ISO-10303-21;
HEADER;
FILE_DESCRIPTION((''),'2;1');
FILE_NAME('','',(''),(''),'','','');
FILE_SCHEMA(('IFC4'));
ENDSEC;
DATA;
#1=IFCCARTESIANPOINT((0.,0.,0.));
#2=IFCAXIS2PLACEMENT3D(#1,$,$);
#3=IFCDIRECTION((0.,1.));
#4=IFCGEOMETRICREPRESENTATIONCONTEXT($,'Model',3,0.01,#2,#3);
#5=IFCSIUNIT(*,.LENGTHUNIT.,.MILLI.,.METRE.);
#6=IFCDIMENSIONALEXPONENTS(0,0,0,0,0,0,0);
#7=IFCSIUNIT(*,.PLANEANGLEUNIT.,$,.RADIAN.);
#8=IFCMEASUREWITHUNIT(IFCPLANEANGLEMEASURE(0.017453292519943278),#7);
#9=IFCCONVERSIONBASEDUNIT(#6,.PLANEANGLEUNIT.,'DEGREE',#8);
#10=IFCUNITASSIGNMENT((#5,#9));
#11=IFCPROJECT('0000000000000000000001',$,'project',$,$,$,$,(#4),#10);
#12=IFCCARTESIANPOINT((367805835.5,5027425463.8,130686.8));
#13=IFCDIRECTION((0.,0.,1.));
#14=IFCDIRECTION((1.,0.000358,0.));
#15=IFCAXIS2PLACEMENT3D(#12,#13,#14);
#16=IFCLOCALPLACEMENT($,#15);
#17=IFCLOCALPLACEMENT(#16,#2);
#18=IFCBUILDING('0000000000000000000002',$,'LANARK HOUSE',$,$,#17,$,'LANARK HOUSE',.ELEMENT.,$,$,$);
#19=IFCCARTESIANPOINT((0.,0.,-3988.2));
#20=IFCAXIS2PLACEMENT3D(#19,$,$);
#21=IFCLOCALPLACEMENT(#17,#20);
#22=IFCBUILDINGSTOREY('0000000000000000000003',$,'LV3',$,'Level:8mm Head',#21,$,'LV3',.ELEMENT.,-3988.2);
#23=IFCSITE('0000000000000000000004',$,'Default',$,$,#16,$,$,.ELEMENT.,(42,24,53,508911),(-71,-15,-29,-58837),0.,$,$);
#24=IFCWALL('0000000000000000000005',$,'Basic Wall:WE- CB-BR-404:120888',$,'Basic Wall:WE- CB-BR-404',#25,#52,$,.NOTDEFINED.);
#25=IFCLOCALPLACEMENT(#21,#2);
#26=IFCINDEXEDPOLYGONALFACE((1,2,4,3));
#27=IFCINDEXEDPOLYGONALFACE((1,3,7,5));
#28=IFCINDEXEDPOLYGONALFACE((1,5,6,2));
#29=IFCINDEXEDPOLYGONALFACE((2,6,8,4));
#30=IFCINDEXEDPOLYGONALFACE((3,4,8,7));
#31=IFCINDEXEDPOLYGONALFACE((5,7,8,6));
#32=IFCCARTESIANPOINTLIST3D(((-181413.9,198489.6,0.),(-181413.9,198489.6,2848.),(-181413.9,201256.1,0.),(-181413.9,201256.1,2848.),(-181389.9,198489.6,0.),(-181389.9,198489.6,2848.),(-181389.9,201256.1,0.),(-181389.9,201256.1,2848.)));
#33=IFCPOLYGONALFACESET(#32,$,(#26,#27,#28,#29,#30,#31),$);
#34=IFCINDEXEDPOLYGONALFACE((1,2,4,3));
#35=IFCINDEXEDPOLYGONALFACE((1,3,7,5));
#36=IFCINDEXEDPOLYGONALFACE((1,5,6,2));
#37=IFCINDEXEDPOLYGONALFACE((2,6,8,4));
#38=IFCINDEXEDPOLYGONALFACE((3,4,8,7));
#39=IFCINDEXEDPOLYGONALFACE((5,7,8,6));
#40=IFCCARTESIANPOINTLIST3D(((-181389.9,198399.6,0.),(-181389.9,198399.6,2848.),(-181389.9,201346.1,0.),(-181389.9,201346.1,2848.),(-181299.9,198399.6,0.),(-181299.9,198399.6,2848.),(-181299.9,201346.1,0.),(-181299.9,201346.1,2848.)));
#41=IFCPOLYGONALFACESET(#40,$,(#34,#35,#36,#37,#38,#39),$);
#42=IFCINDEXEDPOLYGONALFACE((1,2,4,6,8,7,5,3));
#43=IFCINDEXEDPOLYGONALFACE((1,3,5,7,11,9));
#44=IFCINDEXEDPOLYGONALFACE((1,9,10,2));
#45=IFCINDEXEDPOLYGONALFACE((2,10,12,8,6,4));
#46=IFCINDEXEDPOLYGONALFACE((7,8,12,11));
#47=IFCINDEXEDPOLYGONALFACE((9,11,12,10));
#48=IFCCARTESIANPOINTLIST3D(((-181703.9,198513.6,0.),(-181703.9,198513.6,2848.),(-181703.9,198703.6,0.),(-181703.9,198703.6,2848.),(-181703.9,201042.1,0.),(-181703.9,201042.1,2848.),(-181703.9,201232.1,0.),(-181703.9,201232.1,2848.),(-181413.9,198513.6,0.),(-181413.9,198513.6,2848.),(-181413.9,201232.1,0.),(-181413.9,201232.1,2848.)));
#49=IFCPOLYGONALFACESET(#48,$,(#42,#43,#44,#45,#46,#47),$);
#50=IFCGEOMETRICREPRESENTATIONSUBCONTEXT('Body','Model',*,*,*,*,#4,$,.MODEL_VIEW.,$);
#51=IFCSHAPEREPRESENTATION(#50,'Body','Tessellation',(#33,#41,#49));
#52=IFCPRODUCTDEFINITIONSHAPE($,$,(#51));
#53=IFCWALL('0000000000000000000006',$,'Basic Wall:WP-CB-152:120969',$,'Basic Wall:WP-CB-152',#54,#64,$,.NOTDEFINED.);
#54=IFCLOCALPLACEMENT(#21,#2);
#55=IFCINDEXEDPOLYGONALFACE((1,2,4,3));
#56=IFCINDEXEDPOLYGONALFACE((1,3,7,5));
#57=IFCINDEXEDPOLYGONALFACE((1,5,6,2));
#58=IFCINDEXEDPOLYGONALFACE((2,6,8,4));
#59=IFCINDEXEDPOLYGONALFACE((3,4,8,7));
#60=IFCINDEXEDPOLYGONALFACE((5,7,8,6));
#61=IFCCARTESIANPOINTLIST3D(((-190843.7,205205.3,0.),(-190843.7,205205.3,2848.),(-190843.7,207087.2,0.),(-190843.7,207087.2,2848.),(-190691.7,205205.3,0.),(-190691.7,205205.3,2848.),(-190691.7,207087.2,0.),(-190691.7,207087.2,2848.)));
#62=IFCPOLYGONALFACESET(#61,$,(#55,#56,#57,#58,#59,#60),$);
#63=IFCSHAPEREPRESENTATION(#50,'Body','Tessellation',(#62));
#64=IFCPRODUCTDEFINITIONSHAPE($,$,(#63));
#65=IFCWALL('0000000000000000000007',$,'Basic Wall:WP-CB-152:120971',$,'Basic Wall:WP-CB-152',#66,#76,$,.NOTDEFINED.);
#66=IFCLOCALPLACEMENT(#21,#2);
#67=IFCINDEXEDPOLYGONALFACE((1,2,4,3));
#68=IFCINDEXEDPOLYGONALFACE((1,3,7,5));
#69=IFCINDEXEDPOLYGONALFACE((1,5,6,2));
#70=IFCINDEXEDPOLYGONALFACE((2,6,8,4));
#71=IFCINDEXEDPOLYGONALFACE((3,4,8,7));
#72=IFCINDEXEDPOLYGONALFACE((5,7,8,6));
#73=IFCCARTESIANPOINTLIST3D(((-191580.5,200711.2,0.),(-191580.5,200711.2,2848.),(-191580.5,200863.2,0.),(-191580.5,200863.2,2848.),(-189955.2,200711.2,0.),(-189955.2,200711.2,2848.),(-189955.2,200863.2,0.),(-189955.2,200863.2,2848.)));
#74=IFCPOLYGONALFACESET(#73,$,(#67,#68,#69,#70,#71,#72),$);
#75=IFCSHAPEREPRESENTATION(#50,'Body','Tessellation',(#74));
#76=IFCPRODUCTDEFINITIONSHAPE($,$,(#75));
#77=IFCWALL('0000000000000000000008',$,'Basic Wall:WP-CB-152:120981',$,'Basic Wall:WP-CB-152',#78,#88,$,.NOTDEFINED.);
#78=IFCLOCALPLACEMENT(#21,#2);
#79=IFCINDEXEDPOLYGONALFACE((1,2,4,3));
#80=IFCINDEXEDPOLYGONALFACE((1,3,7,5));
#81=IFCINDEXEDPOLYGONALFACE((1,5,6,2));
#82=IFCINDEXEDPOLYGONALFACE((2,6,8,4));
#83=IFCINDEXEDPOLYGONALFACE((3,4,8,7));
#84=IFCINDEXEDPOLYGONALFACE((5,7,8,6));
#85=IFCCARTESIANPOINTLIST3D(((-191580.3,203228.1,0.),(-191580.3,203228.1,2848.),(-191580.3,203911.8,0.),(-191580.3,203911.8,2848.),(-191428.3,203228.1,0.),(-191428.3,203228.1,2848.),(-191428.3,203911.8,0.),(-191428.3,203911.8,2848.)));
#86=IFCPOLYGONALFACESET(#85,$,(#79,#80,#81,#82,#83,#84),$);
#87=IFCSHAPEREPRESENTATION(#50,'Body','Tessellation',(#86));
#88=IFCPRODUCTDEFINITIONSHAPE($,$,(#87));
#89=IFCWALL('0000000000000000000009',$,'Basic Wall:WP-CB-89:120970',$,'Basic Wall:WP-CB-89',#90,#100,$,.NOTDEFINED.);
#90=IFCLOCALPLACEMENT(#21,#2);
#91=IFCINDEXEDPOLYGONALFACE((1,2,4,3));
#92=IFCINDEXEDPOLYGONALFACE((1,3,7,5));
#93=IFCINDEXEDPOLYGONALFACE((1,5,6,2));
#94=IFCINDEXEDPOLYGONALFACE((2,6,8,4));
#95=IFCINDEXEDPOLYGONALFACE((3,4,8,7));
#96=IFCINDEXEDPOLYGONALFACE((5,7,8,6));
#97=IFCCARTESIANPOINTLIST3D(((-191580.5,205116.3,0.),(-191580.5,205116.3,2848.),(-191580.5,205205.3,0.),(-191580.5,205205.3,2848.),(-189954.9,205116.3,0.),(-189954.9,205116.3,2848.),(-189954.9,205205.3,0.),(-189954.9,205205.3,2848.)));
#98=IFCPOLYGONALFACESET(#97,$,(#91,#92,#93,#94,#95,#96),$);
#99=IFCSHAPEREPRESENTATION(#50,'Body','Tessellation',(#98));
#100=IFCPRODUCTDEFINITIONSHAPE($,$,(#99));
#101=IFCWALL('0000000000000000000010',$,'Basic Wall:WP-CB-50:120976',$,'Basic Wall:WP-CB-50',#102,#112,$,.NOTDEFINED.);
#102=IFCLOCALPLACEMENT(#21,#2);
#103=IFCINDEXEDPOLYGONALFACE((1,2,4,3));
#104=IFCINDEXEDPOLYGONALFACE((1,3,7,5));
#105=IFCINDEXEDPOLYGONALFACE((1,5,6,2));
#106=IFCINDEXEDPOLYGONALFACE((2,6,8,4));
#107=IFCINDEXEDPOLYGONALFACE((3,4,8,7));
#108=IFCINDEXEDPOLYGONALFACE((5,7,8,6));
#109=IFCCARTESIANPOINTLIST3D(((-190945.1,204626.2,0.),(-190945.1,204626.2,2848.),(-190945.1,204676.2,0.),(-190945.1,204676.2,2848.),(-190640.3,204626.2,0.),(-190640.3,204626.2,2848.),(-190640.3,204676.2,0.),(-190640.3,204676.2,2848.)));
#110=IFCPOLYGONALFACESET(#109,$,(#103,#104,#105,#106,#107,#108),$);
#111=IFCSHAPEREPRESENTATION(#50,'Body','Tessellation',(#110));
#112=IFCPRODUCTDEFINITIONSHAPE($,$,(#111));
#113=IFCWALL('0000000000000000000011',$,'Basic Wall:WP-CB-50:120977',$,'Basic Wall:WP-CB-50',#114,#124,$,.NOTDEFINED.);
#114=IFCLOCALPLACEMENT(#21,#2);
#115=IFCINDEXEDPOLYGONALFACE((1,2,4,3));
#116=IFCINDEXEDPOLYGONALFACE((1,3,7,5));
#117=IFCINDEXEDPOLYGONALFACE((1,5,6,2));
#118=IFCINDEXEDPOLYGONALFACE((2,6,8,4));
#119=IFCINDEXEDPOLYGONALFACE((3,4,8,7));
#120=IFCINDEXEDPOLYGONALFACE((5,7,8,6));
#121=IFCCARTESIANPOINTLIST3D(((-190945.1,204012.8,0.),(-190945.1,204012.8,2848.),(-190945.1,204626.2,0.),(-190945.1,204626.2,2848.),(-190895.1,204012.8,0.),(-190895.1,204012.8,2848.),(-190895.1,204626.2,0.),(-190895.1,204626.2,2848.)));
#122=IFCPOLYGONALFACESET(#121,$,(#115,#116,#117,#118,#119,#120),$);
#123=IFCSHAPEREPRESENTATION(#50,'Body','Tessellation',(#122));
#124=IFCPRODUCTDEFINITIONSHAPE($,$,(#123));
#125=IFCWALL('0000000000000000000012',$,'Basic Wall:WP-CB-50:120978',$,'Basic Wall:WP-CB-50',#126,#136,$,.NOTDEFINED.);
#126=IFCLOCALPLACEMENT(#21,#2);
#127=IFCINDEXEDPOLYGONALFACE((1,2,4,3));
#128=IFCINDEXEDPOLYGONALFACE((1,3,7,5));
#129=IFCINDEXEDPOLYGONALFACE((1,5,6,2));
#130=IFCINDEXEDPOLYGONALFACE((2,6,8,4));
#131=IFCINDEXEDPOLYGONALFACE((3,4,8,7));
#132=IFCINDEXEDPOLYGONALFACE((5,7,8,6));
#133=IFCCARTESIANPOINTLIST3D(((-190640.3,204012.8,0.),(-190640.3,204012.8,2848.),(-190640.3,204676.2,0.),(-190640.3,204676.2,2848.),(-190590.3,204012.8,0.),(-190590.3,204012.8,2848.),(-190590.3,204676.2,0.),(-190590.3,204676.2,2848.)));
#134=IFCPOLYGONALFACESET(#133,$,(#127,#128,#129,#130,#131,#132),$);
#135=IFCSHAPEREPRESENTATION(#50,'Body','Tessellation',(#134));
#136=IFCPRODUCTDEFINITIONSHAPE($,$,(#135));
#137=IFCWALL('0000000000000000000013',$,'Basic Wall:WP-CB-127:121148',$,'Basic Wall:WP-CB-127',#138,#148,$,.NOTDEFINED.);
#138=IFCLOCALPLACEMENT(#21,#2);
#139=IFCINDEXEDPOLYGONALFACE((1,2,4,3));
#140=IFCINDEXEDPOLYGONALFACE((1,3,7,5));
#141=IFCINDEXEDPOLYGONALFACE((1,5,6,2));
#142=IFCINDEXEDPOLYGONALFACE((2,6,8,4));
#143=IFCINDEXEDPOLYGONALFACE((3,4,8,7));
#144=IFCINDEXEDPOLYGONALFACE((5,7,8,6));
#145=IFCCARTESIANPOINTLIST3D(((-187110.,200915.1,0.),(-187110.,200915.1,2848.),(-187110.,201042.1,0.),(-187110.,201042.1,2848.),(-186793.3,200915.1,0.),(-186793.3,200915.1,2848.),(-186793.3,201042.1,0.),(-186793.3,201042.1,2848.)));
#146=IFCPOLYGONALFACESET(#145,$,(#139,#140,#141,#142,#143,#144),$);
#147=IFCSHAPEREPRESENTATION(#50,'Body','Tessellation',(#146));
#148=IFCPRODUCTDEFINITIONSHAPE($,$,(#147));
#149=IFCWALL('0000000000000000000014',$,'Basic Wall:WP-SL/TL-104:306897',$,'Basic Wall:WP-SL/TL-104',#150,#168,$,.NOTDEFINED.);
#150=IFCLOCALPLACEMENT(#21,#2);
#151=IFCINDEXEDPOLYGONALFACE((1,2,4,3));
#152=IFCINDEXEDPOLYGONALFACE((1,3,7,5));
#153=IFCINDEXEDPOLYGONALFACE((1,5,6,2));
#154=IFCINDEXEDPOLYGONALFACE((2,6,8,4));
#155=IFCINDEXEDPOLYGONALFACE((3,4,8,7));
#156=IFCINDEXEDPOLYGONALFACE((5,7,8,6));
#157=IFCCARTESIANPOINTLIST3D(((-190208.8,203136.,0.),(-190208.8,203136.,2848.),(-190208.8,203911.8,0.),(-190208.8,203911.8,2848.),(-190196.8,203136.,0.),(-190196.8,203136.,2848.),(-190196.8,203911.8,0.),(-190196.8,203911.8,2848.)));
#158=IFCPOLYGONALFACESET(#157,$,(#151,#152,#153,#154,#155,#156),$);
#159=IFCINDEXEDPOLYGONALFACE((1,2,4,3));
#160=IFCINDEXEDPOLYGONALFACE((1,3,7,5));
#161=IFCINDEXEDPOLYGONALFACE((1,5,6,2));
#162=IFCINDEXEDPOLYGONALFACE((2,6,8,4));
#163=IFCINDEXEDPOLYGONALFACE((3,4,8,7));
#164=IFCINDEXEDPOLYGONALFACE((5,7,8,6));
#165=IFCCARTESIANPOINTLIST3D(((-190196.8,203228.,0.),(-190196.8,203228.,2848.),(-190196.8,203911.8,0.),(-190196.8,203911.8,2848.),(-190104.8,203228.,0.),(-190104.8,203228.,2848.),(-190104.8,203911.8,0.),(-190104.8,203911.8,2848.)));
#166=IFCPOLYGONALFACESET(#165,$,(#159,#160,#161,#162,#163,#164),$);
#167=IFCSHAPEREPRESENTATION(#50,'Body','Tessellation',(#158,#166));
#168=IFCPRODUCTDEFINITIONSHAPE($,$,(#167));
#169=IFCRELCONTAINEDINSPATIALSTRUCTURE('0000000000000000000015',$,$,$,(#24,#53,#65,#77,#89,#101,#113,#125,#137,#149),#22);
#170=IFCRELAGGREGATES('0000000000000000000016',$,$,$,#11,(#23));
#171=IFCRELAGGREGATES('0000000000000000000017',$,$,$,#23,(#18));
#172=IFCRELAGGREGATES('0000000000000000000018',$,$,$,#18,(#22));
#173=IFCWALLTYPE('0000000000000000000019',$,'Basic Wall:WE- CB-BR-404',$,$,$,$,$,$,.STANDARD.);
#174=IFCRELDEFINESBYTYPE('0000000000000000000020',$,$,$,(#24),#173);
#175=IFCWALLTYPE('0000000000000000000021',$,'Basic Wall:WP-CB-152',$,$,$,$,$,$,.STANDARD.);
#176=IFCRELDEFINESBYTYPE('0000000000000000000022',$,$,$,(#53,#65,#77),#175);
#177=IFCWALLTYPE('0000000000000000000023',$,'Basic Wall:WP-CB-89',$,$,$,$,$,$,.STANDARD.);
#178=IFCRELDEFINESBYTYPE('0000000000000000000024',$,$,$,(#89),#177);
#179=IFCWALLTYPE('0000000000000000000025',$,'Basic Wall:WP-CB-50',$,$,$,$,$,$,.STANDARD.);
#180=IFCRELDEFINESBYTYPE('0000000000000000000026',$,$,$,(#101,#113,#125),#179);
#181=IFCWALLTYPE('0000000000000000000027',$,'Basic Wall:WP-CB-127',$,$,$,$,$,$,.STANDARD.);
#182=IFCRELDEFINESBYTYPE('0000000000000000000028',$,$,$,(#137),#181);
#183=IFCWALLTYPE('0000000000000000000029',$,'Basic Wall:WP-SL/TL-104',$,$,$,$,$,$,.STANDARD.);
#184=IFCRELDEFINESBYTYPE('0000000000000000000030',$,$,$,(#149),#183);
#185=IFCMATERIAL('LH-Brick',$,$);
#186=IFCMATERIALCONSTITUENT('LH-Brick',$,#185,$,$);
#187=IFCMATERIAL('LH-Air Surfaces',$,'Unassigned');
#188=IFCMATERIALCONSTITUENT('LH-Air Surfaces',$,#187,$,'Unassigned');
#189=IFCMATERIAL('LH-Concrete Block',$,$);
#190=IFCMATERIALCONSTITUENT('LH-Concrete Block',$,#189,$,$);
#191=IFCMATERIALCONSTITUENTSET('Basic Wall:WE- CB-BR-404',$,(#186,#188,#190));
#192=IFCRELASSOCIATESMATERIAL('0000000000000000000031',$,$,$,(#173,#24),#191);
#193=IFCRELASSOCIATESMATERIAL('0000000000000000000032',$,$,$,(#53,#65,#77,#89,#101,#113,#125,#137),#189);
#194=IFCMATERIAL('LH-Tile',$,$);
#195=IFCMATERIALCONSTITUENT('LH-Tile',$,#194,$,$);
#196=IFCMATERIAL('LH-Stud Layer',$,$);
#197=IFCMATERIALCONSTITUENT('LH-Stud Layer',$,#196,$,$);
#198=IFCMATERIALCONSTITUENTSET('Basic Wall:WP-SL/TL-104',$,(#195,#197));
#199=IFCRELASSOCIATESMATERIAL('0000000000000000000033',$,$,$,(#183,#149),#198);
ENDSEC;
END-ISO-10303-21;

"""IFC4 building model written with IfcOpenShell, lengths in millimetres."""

from ifc_helpers import new_model, entity, si_unit, converted_unit, direction, frame, origin, place, context, subcontext, project, spatial, indexed_curve, outline, extrude, material, constituent, constituent_set, type_object, element, save


model = new_model("IFC4")

# Units and contexts
model_context = context("Model", 3, precision=0.01, world=origin(), true_north=direction((0.0, 1.0)))
body_context = subcontext(model_context, "Body", "Model", "MODEL_VIEW")
ifc_project = project(units=[si_unit("LENGTHUNIT", "METRE", prefix="MILLI"), converted_unit("PLANEANGLEUNIT", "DEGREE", entity("IfcPlaneAngleMeasure", 0.017453292519943278), si_unit("PLANEANGLEUNIT", "RADIAN"), dimensions=[0, 0, 0, 0, 0, 0, 0])], contexts=[model_context])

# Site, building, storey
site_placement = place(None, frame((367805835.5, 5027425463.8, 130686.8), z_axis=(0.0, 0.0, 1.0), x_axis=(1.0, 0.000358, 0.0)))
site = spatial("IfcSite", under=ifc_project, at=site_placement, Name="Default", CompositionType="ELEMENT", RefLatitude=(42, 24, 53, 508911), RefLongitude=(-71, -15, -29, -58837), RefElevation=0.0)
building_placement = place(site_placement, origin())
building = spatial("IfcBuilding", under=site, at=building_placement, Name="LANARK HOUSE", LongName="LANARK HOUSE", CompositionType="ELEMENT")
storey_placement = place(building_placement, frame((0.0, 0.0, -3988.2)))
storey = spatial("IfcBuildingStorey", under=building, at=storey_placement, Name="LV3", ObjectType="Level:8mm Head", LongName="LV3", CompositionType="ELEMENT", Elevation=-3988.2)

# Shared definitions
ifc_material_1 = material(Name="LH-Brick")
ifc_material_2 = material(Name="LH-Air Surfaces", Category="Unassigned")
ifc_material_3 = material(Name="LH-Concrete Block")

# Walls
ifc_constituent_1 = constituent(ifc_material_1, Name="LH-Brick")
ifc_constituent_2 = constituent(ifc_material_2, Name="LH-Air Surfaces", Category="Unassigned")
ifc_constituent_3 = constituent(ifc_material_3, Name="LH-Concrete Block")
ifc_constituent_set_1 = constituent_set(constituents=[ifc_constituent_1, ifc_constituent_2, ifc_constituent_3], Name="Basic Wall:WE- CB-BR-404")
wall_type_1 = type_object("IfcWallType", Name="Basic Wall:WE- CB-BR-404", PredefinedType="STANDARD", material=ifc_constituent_set_1)
wall_1_placement = place(storey_placement, frame((-181501.9, 201346.1, 0.0), z_axis=(0.0, 0.0, 1.0), x_axis=(0.0, -1.0, 0.0)))
element("IfcWall", 1, at=wall_1_placement, inside=storey, type_object=wall_type_1, material=ifc_constituent_set_1, Name="Basic Wall:WE- CB-BR-404:120888", ObjectType="Basic Wall:WE- CB-BR-404", PredefinedType="NOTDEFINED", context=body_context, shape_type="SweptSolid", body=[
    extrude(outline(indexed_curve([(-1383.2, -12.0), (1383.2, -12.0), (1383.2, 12.0), (-1383.2, 12.0), (-1383.2, -12.0)], self_intersect=False)), frame((1473.2, 100.0, 0.0)), (0.0, 0.0, 1.0), 2848.0),
    extrude(outline(indexed_curve([(-45.0, -1473.2), (45.0, -1473.2), (45.0, 1473.2), (-45.0, 1473.2), (-45.0, -1473.2)], self_intersect=False)), frame((1473.2, 157.0, 0.0), z_axis=(0.0, 0.0, 1.0), x_axis=(0.0, -1.0, 0.0)), (0.0, 0.0, 1.0), 2848.0),
    extrude(outline(indexed_curve([(-1169.2, -96.7), (1169.2, -96.7), (1359.2, -96.7), (1359.2, 193.3), (-1359.2, 193.3), (-1359.2, -96.7), (-1169.2, -96.7)], self_intersect=False)), frame((1473.2, -105.3, 0.0)), (0.0, 0.0, 1.0), 2848.0),
])
wall_type_2 = type_object("IfcWallType", Name="Basic Wall:WP-CB-152", PredefinedType="STANDARD")
wall_2_placement = place(storey_placement, frame((-190767.7, 205205.3, 0.0), z_axis=(0.0, 0.0, 1.0), x_axis=(0.0, 1.0, 0.0)))
element("IfcWall", 2, at=wall_2_placement, inside=storey, type_object=wall_type_2, material=ifc_material_3, Name="Basic Wall:WP-CB-152:120969", ObjectType="Basic Wall:WP-CB-152", PredefinedType="NOTDEFINED", context=body_context, shape_type="SweptSolid", body=[
    extrude(outline(indexed_curve([(1881.9, 76.0), (0.0, 76.0), (0.0, -76.0), (1881.9, -76.0), (1881.9, 76.0)], self_intersect=False)), origin(), (0.0, 0.0, 1.0), 2848.0),
])
wall_3_placement = place(storey_placement, frame((-189955.2, 200787.2, 0.0), z_axis=(0.0, 0.0, 1.0), x_axis=(-1.0, 0.0, 0.0)))
element("IfcWall", 3, at=wall_3_placement, inside=storey, type_object=wall_type_2, material=ifc_material_3, Name="Basic Wall:WP-CB-152:120971", ObjectType="Basic Wall:WP-CB-152", PredefinedType="NOTDEFINED", context=body_context, shape_type="SweptSolid", body=[
    extrude(outline(indexed_curve([(1625.3, 76.0), (0.0, 76.0), (0.0, -76.0), (1625.3, -76.0), (1625.3, 76.0)], self_intersect=False)), origin(), (0.0, 0.0, 1.0), 2848.0),
])
wall_4_placement = place(storey_placement, frame((-191504.3, 203228.1, 0.0), z_axis=(0.0, 0.0, 1.0), x_axis=(0.0, 1.0, 0.0)))
element("IfcWall", 4, at=wall_4_placement, inside=storey, type_object=wall_type_2, material=ifc_material_3, Name="Basic Wall:WP-CB-152:120981", ObjectType="Basic Wall:WP-CB-152", PredefinedType="NOTDEFINED", context=body_context, shape_type="SweptSolid", body=[
    extrude(outline(indexed_curve([(683.7, 76.0), (0.0, 76.0), (0.0, -76.0), (683.7, -76.0), (683.7, 76.0)], self_intersect=False)), origin(), (0.0, 0.0, 1.0), 2848.0),
])
wall_type_3 = type_object("IfcWallType", Name="Basic Wall:WP-CB-89", PredefinedType="STANDARD")
wall_5_placement = place(storey_placement, frame((-189954.9, 205160.8, 0.0), z_axis=(0.0, 0.0, 1.0), x_axis=(-1.0, 0.0, 0.0)))
element("IfcWall", 5, at=wall_5_placement, inside=storey, type_object=wall_type_3, material=ifc_material_3, Name="Basic Wall:WP-CB-89:120970", ObjectType="Basic Wall:WP-CB-89", PredefinedType="NOTDEFINED", context=body_context, shape_type="SweptSolid", body=[
    extrude(outline(indexed_curve([(1625.6, 44.5), (0.0, 44.5), (0.0, -44.5), (1625.6, -44.5), (1625.6, 44.5)], self_intersect=False)), origin(), (0.0, 0.0, 1.0), 2848.0),
])
wall_type_4 = type_object("IfcWallType", Name="Basic Wall:WP-CB-50", PredefinedType="STANDARD")
wall_6_placement = place(storey_placement, frame((-190945.1, 204651.2, 0.0)))
element("IfcWall", 6, at=wall_6_placement, inside=storey, type_object=wall_type_4, material=ifc_material_3, Name="Basic Wall:WP-CB-50:120976", ObjectType="Basic Wall:WP-CB-50", PredefinedType="NOTDEFINED", context=body_context, shape_type="SweptSolid", body=[
    extrude(outline(indexed_curve([(304.8, 25.0), (0.0, 25.0), (0.0, -25.0), (304.8, -25.0), (304.8, 25.0)], self_intersect=False)), origin(), (0.0, 0.0, 1.0), 2848.0),
])
wall_7_placement = place(storey_placement, frame((-190920.1, 204012.8, 0.0), z_axis=(0.0, 0.0, 1.0), x_axis=(0.0, 1.0, 0.0)))
element("IfcWall", 7, at=wall_7_placement, inside=storey, type_object=wall_type_4, material=ifc_material_3, Name="Basic Wall:WP-CB-50:120977", ObjectType="Basic Wall:WP-CB-50", PredefinedType="NOTDEFINED", context=body_context, shape_type="SweptSolid", body=[
    extrude(outline(indexed_curve([(613.5, 25.0), (0.0, 25.0), (0.0, -25.0), (613.5, -25.0), (613.5, 25.0)], self_intersect=False)), origin(), (0.0, 0.0, 1.0), 2848.0),
])
wall_8_placement = place(storey_placement, frame((-190615.3, 204012.8, 0.0), z_axis=(0.0, 0.0, 1.0), x_axis=(0.0, 1.0, 0.0)))
element("IfcWall", 8, at=wall_8_placement, inside=storey, type_object=wall_type_4, material=ifc_material_3, Name="Basic Wall:WP-CB-50:120978", ObjectType="Basic Wall:WP-CB-50", PredefinedType="NOTDEFINED", context=body_context, shape_type="SweptSolid", body=[
    extrude(outline(indexed_curve([(663.5, 25.0), (0.0, 25.0), (0.0, -25.0), (663.5, -25.0), (663.5, 25.0)], self_intersect=False)), origin(), (0.0, 0.0, 1.0), 2848.0),
])
wall_type_5 = type_object("IfcWallType", Name="Basic Wall:WP-CB-127", PredefinedType="STANDARD")
wall_9_placement = place(storey_placement, frame((-187110.0, 200978.6, 0.0)))
element("IfcWall", 9, at=wall_9_placement, inside=storey, type_object=wall_type_5, material=ifc_material_3, Name="Basic Wall:WP-CB-127:121148", ObjectType="Basic Wall:WP-CB-127", PredefinedType="NOTDEFINED", context=body_context, shape_type="SweptSolid", body=[
    extrude(outline(indexed_curve([(316.7, 63.5), (0.0, 63.5), (0.0, -63.5), (316.7, -63.5), (316.7, 63.5)], self_intersect=False)), origin(), (0.0, 0.0, 1.0), 2848.0),
])

# Shared definitions
ifc_material_4 = material(Name="LH-Stud Layer")

# Wall
ifc_material_5 = material(Name="LH-Tile")
ifc_constituent_4 = constituent(ifc_material_5, Name="LH-Tile")
ifc_constituent_5 = constituent(ifc_material_4, Name="LH-Stud Layer")
ifc_constituent_set_2 = constituent_set(constituents=[ifc_constituent_4, ifc_constituent_5], Name="Basic Wall:WP-SL/TL-104")
wall_type_6 = type_object("IfcWallType", Name="Basic Wall:WP-SL/TL-104", PredefinedType="STANDARD", material=ifc_constituent_set_2)
wall_10_placement = place(storey_placement, frame((-190156.8, 203228.0, 0.0), z_axis=(0.0, 0.0, 1.0), x_axis=(0.0, 1.0, 0.0)))
element("IfcWall", 10, at=wall_10_placement, inside=storey, type_object=wall_type_6, material=ifc_constituent_set_2, Name="Basic Wall:WP-SL/TL-104:306897", ObjectType="Basic Wall:WP-SL/TL-104", PredefinedType="NOTDEFINED", context=body_context, shape_type="SweptSolid", body=[
    extrude(outline(indexed_curve([(-6.0, -387.9), (6.0, -387.9), (6.0, 387.9), (-6.0, 387.9), (-6.0, -387.9)], self_intersect=False)), frame((295.9, 46.0, 0.0), z_axis=(0.0, 0.0, 1.0), x_axis=(0.0, -1.0, 0.0)), (0.0, 0.0, 1.0), 2848.0),
    extrude(outline(indexed_curve([(-46.0, -341.9), (46.0, -341.9), (46.0, 341.9), (-46.0, 341.9), (-46.0, -341.9)], self_intersect=False)), frame((341.9, -6.0, 0.0), z_axis=(0.0, 0.0, 1.0), x_axis=(0.0, 1.0, 0.0)), (0.0, 0.0, 1.0), 2848.0),
])

save(model, "model.ifc")
